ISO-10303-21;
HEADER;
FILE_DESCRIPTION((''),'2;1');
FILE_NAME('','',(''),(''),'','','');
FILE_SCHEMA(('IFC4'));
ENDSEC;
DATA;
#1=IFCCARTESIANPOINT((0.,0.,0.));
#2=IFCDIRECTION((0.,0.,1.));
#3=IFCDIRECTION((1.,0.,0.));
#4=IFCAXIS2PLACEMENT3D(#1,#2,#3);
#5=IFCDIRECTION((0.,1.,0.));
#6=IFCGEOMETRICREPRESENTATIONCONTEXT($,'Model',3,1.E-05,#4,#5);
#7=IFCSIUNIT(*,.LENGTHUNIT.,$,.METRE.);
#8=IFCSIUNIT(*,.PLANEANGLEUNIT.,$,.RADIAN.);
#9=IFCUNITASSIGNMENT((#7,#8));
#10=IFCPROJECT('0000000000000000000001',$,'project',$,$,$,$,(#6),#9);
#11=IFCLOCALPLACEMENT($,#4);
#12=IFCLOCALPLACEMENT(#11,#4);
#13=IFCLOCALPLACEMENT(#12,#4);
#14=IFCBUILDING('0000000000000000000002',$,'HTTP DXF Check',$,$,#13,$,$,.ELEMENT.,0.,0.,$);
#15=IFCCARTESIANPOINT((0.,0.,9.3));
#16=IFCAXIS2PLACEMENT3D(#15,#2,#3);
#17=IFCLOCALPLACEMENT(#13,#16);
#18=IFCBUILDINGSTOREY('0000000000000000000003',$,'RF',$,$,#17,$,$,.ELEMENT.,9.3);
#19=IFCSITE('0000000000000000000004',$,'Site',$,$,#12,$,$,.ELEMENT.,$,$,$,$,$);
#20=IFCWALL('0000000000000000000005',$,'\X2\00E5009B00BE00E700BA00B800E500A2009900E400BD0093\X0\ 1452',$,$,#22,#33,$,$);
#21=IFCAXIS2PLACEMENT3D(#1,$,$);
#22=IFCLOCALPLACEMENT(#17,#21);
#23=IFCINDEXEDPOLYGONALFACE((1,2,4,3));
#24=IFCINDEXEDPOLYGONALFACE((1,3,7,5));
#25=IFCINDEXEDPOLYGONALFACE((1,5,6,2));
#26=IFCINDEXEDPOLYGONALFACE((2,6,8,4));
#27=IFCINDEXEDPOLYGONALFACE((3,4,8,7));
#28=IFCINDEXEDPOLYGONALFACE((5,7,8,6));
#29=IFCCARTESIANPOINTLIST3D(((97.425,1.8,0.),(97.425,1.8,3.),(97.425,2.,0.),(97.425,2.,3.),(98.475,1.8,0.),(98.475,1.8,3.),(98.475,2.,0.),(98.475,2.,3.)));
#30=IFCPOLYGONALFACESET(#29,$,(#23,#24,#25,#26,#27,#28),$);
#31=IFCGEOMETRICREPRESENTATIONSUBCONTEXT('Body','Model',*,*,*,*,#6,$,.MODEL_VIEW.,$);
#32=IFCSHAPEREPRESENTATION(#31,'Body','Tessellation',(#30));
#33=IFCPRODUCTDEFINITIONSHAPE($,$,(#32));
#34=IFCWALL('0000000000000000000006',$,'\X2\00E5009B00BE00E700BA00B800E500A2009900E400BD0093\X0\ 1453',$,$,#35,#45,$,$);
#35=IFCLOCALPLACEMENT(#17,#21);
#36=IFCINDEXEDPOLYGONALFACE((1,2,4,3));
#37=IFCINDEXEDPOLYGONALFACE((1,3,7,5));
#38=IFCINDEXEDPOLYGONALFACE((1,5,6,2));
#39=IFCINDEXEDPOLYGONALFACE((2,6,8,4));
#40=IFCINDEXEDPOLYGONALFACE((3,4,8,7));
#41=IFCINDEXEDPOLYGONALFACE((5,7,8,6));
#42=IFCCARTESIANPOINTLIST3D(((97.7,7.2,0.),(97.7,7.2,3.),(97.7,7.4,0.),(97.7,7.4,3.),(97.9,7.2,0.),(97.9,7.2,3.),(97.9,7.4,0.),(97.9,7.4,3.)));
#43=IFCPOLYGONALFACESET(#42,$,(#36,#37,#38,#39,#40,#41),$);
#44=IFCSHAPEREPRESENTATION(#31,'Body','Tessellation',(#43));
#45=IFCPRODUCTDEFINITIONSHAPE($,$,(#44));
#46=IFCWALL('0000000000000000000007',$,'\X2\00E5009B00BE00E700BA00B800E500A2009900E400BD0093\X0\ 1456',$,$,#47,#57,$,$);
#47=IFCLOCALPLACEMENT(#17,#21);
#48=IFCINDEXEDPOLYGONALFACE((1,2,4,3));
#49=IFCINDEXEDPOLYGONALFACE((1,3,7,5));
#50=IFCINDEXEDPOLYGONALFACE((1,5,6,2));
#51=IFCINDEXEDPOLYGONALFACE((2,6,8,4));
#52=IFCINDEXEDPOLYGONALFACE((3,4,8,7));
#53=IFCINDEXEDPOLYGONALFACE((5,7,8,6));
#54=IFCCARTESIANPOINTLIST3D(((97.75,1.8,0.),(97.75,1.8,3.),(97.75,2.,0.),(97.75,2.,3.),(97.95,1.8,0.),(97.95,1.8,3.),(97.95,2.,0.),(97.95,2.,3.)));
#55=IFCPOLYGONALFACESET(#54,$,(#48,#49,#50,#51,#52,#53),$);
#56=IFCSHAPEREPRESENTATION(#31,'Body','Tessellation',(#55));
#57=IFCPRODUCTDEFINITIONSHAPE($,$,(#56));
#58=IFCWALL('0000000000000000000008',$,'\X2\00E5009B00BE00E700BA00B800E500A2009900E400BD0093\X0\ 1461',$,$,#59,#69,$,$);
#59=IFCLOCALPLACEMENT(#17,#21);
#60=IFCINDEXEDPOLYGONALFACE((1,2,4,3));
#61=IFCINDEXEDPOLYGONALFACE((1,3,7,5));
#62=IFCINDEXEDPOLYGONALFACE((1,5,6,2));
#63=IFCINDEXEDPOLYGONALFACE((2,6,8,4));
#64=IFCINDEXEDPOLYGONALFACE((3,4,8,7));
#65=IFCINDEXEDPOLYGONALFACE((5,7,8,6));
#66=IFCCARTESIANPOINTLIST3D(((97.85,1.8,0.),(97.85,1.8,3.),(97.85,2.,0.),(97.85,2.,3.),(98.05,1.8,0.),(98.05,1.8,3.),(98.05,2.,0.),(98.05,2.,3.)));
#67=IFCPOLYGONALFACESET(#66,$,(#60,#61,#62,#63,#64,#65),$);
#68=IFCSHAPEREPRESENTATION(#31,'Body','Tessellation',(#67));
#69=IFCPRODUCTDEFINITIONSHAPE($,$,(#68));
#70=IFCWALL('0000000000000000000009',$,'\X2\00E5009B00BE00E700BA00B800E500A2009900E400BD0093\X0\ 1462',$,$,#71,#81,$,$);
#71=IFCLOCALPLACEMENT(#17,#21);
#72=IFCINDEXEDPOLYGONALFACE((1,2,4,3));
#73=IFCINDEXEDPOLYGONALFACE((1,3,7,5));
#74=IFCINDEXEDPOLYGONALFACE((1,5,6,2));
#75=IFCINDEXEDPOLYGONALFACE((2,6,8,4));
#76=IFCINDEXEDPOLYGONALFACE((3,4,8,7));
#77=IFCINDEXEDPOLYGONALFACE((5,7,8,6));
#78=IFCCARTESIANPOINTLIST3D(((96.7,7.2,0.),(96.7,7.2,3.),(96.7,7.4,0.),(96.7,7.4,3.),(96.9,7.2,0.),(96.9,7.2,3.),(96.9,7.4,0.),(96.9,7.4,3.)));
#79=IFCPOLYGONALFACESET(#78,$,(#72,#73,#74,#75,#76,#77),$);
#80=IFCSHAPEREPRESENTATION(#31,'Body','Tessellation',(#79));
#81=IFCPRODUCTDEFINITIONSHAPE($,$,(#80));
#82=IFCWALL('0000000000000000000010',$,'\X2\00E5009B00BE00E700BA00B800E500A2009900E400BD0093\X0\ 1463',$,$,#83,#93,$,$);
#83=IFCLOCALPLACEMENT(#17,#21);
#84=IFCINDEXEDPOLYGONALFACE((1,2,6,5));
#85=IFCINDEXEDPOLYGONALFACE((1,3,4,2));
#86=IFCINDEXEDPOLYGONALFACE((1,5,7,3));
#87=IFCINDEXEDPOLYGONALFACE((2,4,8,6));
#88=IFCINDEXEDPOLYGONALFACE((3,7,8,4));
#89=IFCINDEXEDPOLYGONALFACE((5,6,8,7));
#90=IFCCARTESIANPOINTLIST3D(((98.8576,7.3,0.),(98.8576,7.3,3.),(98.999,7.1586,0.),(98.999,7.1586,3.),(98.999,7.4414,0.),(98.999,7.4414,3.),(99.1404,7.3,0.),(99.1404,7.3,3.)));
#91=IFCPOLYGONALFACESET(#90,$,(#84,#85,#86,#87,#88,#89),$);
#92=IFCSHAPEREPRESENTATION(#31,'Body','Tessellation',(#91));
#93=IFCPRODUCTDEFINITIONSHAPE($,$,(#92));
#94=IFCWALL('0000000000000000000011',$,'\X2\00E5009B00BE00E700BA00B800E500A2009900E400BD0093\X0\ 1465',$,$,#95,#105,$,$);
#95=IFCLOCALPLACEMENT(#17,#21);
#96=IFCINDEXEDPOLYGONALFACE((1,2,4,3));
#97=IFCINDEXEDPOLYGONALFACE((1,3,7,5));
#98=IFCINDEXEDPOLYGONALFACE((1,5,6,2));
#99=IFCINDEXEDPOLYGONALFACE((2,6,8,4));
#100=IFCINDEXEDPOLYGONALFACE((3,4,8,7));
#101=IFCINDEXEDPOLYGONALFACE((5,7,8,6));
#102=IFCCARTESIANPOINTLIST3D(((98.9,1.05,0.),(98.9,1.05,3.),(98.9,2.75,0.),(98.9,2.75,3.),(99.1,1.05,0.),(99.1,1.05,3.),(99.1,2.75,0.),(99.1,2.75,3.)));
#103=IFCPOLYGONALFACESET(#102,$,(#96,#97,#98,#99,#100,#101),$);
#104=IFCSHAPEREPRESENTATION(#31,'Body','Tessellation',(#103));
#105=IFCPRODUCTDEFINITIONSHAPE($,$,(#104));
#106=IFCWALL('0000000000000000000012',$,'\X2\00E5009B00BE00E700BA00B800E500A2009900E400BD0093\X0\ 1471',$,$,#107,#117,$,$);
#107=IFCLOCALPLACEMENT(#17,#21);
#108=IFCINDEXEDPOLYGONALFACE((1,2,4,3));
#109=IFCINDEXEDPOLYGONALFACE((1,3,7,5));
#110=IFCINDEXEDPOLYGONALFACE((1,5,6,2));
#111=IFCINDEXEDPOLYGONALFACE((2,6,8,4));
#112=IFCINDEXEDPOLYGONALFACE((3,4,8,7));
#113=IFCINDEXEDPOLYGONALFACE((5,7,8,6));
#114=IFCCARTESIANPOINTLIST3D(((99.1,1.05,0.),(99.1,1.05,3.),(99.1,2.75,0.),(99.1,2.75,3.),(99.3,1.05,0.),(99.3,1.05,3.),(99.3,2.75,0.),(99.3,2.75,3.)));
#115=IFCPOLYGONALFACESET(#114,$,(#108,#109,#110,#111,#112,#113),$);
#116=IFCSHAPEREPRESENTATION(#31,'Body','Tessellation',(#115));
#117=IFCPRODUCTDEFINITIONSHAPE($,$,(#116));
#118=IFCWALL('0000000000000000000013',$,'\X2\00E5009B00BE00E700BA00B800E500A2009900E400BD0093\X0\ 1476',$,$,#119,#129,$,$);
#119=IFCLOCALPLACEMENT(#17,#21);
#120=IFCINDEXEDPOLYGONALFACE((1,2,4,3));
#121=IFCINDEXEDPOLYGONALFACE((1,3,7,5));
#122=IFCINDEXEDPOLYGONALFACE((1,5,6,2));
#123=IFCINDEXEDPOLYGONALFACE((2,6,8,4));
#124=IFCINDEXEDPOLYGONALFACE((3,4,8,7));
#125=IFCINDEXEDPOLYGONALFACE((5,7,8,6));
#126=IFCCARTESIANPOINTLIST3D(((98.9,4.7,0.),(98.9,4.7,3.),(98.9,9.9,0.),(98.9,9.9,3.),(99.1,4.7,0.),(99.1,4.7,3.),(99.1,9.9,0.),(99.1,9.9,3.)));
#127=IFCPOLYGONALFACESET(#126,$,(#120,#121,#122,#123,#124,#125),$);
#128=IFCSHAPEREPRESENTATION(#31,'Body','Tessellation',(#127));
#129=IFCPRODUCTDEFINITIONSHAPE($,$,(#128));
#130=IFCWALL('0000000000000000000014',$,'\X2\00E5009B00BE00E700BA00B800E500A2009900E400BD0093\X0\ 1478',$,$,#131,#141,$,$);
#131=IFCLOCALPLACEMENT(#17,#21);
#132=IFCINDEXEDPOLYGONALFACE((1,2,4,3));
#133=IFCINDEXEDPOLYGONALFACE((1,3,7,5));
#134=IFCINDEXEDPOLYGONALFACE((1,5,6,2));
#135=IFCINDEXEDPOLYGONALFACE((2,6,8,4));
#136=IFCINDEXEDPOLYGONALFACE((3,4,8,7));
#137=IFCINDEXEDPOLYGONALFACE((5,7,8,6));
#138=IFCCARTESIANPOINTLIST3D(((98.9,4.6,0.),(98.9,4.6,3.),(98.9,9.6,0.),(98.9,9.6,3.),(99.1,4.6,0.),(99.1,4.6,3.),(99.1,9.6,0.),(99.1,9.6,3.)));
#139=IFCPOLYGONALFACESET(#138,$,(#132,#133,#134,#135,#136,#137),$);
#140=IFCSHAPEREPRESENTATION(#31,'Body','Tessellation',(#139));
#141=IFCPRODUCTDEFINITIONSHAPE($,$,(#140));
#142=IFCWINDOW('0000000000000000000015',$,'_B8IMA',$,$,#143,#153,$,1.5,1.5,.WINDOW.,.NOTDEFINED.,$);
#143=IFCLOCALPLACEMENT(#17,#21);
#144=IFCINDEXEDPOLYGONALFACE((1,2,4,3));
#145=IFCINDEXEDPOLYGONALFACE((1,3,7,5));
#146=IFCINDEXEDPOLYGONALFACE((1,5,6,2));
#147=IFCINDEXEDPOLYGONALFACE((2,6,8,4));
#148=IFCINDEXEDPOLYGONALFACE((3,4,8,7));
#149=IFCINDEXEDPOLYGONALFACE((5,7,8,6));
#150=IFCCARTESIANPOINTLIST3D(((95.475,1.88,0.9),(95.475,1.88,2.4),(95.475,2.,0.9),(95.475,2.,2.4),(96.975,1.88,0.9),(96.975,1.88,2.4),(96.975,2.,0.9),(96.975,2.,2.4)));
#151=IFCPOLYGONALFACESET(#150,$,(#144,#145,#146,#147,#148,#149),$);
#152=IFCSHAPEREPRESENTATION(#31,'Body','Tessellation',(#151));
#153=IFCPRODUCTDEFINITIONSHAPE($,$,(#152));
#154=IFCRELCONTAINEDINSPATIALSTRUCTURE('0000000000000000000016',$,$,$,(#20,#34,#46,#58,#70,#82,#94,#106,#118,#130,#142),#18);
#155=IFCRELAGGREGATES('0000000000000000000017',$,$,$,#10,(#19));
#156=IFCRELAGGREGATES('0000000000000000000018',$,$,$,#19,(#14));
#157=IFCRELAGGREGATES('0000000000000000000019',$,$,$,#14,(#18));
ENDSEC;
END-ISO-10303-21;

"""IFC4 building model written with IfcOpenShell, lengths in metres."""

from ifc_helpers import new_model, si_unit, direction, frame, frame_2d, origin_with_axes, place, context, subcontext, project, spatial, rectangle, extrude, element, save


model = new_model("IFC4")

# Units and contexts
model_context = context("Model", 3, precision=1e-05, world=origin_with_axes(), true_north=direction((0.0, 1.0, 0.0)))
body_context = subcontext(model_context, "Body", "Model", "MODEL_VIEW")
ifc_project = project(units=[si_unit("LENGTHUNIT", "METRE"), si_unit("PLANEANGLEUNIT", "RADIAN")], contexts=[model_context])

# Site, building, storey
placement = place(None, origin_with_axes())
site_placement = place(placement, origin_with_axes())
site = spatial("IfcSite", under=ifc_project, at=site_placement, Name="Site", CompositionType="ELEMENT")
building_placement = place(site_placement, origin_with_axes())
building = spatial("IfcBuilding", under=site, at=building_placement, Name="HTTP DXF Check", CompositionType="ELEMENT", ElevationOfRefHeight=0.0, ElevationOfTerrain=0.0)
storey_placement = place(building_placement, frame((0.0, 0.0, 9.3), z_axis=(0.0, 0.0, 1.0), x_axis=(1.0, 0.0, 0.0)))
storey = spatial("IfcBuildingStorey", under=building, at=storey_placement, Name="RF", CompositionType="ELEMENT", Elevation=9.3)

# Walls
wall_1_placement = place(storey_placement, frame((97.95, 1.9, 0.0), z_axis=(0.0, 0.0, 1.0), x_axis=(1.0, 0.0, 0.0)))
element("IfcWall", 1, at=wall_1_placement, inside=storey, Name="å\u009b¾çº¸å¢\u0099ä½\u0093 1452", context=body_context, shape_type="SweptSolid", body=[
    extrude(rectangle(XDim=1.05, YDim=0.2, at=frame_2d((0.0, 0.0), x_axis=(1.0, 0.0, 0.0))), frame((0.0, 0.0, 0.0), z_axis=(0.0, 0.0, 1.0)), (0.0, 0.0, 1.0), 3.0),
])
for number, where, z_axis, x_axis, name in (
    (2, (97.8, 7.3, 0.0), (0.0, 0.0, 1.0), (0.0, 1.0, 0.0), "å\u009b¾çº¸å¢\u0099ä½\u0093 1453"),
    (3, (97.85, 1.9, 0.0), (0.0, 0.0, 1.0), (0.0, 1.0, 0.0), "å\u009b¾çº¸å¢\u0099ä½\u0093 1456"),
    (4, (97.95, 1.9, 0.0), (0.0, 0.0, 1.0), (0.0, -1.0, 0.0), "å\u009b¾çº¸å¢\u0099ä½\u0093 1461"),
    (5, (96.8, 7.3, 0.0), (0.0, 0.0, 1.0), (0.0, 1.0, 0.0), "å\u009b¾çº¸å¢\u0099ä½\u0093 1462"),
    (6, (98.999, 7.3, 0.0), (0.0, 0.0, 1.0), (0.707107, -0.707107, 0.0), "å\u009b¾çº¸å¢\u0099ä½\u0093 1463"),
):
    element("IfcWall", number, at=place(storey_placement, frame(where, z_axis=z_axis, x_axis=x_axis)), inside=storey, Name=name, context=body_context, shape_type="SweptSolid", body=[
        extrude(rectangle(XDim=0.2, YDim=0.2, at=frame_2d((0.0, 0.0), x_axis=(1.0, 0.0, 0.0))), frame((0.0, 0.0, 0.0), z_axis=(0.0, 0.0, 1.0)), (0.0, 0.0, 1.0), 3.0),
    ])
for number, where, z_axis, x_axis, name in (
    (7, (99.0, 1.9, 0.0), (0.0, 0.0, 1.0), (0.0, -1.0, 0.0), "å\u009b¾çº¸å¢\u0099ä½\u0093 1465"),
    (8, (99.2, 1.9, 0.0), (0.0, 0.0, 1.0), (0.0, -1.0, 0.0), "å\u009b¾çº¸å¢\u0099ä½\u0093 1471"),
):
    element("IfcWall", number, at=place(storey_placement, frame(where, z_axis=z_axis, x_axis=x_axis)), inside=storey, Name=name, context=body_context, shape_type="SweptSolid", body=[
        extrude(rectangle(XDim=1.7, YDim=0.2, at=frame_2d((0.0, 0.0), x_axis=(1.0, 0.0, 0.0))), frame((0.0, 0.0, 0.0), z_axis=(0.0, 0.0, 1.0)), (0.0, 0.0, 1.0), 3.0),
    ])
wall_2_placement = place(storey_placement, frame((99.0, 7.3, 0.0), z_axis=(0.0, 0.0, 1.0), x_axis=(0.0, -1.0, 0.0)))
element("IfcWall", 9, at=wall_2_placement, inside=storey, Name="å\u009b¾çº¸å¢\u0099ä½\u0093 1476", context=body_context, shape_type="SweptSolid", body=[
    extrude(rectangle(XDim=5.2, YDim=0.2, at=frame_2d((0.0, 0.0), x_axis=(1.0, 0.0, 0.0))), frame((0.0, 0.0, 0.0), z_axis=(0.0, 0.0, 1.0)), (0.0, 0.0, 1.0), 3.0),
])
wall_3_placement = place(storey_placement, frame((99.0, 7.1, 0.0), z_axis=(0.0, 0.0, 1.0), x_axis=(0.0, -1.0, 0.0)))
element("IfcWall", 10, at=wall_3_placement, inside=storey, Name="å\u009b¾çº¸å¢\u0099ä½\u0093 1478", context=body_context, shape_type="SweptSolid", body=[
    extrude(rectangle(XDim=5.0, YDim=0.2, at=frame_2d((0.0, 0.0), x_axis=(1.0, 0.0, 0.0))), frame((0.0, 0.0, 0.0), z_axis=(0.0, 0.0, 1.0)), (0.0, 0.0, 1.0), 3.0),
])

# Window
window_placement = place(storey_placement, frame((96.225, 1.94, 0.9), z_axis=(0.0, 0.0, 1.0), x_axis=(1.0, 0.0, 0.0)))
element("IfcWindow", 11, at=window_placement, inside=storey, Name="_B8IMA", OverallHeight=1.5, OverallWidth=1.5, PartitioningType="NOTDEFINED", PredefinedType="WINDOW", context=body_context, shape_type="SweptSolid", body=[
    extrude(rectangle(XDim=1.5, YDim=0.12, at=frame_2d((0.0, 0.0), x_axis=(1.0, 0.0, 0.0))), frame((0.0, 0.0, 0.0), z_axis=(0.0, 0.0, 1.0)), (0.0, 0.0, 1.0), 1.5),
])

save(model, "model.ifc")
